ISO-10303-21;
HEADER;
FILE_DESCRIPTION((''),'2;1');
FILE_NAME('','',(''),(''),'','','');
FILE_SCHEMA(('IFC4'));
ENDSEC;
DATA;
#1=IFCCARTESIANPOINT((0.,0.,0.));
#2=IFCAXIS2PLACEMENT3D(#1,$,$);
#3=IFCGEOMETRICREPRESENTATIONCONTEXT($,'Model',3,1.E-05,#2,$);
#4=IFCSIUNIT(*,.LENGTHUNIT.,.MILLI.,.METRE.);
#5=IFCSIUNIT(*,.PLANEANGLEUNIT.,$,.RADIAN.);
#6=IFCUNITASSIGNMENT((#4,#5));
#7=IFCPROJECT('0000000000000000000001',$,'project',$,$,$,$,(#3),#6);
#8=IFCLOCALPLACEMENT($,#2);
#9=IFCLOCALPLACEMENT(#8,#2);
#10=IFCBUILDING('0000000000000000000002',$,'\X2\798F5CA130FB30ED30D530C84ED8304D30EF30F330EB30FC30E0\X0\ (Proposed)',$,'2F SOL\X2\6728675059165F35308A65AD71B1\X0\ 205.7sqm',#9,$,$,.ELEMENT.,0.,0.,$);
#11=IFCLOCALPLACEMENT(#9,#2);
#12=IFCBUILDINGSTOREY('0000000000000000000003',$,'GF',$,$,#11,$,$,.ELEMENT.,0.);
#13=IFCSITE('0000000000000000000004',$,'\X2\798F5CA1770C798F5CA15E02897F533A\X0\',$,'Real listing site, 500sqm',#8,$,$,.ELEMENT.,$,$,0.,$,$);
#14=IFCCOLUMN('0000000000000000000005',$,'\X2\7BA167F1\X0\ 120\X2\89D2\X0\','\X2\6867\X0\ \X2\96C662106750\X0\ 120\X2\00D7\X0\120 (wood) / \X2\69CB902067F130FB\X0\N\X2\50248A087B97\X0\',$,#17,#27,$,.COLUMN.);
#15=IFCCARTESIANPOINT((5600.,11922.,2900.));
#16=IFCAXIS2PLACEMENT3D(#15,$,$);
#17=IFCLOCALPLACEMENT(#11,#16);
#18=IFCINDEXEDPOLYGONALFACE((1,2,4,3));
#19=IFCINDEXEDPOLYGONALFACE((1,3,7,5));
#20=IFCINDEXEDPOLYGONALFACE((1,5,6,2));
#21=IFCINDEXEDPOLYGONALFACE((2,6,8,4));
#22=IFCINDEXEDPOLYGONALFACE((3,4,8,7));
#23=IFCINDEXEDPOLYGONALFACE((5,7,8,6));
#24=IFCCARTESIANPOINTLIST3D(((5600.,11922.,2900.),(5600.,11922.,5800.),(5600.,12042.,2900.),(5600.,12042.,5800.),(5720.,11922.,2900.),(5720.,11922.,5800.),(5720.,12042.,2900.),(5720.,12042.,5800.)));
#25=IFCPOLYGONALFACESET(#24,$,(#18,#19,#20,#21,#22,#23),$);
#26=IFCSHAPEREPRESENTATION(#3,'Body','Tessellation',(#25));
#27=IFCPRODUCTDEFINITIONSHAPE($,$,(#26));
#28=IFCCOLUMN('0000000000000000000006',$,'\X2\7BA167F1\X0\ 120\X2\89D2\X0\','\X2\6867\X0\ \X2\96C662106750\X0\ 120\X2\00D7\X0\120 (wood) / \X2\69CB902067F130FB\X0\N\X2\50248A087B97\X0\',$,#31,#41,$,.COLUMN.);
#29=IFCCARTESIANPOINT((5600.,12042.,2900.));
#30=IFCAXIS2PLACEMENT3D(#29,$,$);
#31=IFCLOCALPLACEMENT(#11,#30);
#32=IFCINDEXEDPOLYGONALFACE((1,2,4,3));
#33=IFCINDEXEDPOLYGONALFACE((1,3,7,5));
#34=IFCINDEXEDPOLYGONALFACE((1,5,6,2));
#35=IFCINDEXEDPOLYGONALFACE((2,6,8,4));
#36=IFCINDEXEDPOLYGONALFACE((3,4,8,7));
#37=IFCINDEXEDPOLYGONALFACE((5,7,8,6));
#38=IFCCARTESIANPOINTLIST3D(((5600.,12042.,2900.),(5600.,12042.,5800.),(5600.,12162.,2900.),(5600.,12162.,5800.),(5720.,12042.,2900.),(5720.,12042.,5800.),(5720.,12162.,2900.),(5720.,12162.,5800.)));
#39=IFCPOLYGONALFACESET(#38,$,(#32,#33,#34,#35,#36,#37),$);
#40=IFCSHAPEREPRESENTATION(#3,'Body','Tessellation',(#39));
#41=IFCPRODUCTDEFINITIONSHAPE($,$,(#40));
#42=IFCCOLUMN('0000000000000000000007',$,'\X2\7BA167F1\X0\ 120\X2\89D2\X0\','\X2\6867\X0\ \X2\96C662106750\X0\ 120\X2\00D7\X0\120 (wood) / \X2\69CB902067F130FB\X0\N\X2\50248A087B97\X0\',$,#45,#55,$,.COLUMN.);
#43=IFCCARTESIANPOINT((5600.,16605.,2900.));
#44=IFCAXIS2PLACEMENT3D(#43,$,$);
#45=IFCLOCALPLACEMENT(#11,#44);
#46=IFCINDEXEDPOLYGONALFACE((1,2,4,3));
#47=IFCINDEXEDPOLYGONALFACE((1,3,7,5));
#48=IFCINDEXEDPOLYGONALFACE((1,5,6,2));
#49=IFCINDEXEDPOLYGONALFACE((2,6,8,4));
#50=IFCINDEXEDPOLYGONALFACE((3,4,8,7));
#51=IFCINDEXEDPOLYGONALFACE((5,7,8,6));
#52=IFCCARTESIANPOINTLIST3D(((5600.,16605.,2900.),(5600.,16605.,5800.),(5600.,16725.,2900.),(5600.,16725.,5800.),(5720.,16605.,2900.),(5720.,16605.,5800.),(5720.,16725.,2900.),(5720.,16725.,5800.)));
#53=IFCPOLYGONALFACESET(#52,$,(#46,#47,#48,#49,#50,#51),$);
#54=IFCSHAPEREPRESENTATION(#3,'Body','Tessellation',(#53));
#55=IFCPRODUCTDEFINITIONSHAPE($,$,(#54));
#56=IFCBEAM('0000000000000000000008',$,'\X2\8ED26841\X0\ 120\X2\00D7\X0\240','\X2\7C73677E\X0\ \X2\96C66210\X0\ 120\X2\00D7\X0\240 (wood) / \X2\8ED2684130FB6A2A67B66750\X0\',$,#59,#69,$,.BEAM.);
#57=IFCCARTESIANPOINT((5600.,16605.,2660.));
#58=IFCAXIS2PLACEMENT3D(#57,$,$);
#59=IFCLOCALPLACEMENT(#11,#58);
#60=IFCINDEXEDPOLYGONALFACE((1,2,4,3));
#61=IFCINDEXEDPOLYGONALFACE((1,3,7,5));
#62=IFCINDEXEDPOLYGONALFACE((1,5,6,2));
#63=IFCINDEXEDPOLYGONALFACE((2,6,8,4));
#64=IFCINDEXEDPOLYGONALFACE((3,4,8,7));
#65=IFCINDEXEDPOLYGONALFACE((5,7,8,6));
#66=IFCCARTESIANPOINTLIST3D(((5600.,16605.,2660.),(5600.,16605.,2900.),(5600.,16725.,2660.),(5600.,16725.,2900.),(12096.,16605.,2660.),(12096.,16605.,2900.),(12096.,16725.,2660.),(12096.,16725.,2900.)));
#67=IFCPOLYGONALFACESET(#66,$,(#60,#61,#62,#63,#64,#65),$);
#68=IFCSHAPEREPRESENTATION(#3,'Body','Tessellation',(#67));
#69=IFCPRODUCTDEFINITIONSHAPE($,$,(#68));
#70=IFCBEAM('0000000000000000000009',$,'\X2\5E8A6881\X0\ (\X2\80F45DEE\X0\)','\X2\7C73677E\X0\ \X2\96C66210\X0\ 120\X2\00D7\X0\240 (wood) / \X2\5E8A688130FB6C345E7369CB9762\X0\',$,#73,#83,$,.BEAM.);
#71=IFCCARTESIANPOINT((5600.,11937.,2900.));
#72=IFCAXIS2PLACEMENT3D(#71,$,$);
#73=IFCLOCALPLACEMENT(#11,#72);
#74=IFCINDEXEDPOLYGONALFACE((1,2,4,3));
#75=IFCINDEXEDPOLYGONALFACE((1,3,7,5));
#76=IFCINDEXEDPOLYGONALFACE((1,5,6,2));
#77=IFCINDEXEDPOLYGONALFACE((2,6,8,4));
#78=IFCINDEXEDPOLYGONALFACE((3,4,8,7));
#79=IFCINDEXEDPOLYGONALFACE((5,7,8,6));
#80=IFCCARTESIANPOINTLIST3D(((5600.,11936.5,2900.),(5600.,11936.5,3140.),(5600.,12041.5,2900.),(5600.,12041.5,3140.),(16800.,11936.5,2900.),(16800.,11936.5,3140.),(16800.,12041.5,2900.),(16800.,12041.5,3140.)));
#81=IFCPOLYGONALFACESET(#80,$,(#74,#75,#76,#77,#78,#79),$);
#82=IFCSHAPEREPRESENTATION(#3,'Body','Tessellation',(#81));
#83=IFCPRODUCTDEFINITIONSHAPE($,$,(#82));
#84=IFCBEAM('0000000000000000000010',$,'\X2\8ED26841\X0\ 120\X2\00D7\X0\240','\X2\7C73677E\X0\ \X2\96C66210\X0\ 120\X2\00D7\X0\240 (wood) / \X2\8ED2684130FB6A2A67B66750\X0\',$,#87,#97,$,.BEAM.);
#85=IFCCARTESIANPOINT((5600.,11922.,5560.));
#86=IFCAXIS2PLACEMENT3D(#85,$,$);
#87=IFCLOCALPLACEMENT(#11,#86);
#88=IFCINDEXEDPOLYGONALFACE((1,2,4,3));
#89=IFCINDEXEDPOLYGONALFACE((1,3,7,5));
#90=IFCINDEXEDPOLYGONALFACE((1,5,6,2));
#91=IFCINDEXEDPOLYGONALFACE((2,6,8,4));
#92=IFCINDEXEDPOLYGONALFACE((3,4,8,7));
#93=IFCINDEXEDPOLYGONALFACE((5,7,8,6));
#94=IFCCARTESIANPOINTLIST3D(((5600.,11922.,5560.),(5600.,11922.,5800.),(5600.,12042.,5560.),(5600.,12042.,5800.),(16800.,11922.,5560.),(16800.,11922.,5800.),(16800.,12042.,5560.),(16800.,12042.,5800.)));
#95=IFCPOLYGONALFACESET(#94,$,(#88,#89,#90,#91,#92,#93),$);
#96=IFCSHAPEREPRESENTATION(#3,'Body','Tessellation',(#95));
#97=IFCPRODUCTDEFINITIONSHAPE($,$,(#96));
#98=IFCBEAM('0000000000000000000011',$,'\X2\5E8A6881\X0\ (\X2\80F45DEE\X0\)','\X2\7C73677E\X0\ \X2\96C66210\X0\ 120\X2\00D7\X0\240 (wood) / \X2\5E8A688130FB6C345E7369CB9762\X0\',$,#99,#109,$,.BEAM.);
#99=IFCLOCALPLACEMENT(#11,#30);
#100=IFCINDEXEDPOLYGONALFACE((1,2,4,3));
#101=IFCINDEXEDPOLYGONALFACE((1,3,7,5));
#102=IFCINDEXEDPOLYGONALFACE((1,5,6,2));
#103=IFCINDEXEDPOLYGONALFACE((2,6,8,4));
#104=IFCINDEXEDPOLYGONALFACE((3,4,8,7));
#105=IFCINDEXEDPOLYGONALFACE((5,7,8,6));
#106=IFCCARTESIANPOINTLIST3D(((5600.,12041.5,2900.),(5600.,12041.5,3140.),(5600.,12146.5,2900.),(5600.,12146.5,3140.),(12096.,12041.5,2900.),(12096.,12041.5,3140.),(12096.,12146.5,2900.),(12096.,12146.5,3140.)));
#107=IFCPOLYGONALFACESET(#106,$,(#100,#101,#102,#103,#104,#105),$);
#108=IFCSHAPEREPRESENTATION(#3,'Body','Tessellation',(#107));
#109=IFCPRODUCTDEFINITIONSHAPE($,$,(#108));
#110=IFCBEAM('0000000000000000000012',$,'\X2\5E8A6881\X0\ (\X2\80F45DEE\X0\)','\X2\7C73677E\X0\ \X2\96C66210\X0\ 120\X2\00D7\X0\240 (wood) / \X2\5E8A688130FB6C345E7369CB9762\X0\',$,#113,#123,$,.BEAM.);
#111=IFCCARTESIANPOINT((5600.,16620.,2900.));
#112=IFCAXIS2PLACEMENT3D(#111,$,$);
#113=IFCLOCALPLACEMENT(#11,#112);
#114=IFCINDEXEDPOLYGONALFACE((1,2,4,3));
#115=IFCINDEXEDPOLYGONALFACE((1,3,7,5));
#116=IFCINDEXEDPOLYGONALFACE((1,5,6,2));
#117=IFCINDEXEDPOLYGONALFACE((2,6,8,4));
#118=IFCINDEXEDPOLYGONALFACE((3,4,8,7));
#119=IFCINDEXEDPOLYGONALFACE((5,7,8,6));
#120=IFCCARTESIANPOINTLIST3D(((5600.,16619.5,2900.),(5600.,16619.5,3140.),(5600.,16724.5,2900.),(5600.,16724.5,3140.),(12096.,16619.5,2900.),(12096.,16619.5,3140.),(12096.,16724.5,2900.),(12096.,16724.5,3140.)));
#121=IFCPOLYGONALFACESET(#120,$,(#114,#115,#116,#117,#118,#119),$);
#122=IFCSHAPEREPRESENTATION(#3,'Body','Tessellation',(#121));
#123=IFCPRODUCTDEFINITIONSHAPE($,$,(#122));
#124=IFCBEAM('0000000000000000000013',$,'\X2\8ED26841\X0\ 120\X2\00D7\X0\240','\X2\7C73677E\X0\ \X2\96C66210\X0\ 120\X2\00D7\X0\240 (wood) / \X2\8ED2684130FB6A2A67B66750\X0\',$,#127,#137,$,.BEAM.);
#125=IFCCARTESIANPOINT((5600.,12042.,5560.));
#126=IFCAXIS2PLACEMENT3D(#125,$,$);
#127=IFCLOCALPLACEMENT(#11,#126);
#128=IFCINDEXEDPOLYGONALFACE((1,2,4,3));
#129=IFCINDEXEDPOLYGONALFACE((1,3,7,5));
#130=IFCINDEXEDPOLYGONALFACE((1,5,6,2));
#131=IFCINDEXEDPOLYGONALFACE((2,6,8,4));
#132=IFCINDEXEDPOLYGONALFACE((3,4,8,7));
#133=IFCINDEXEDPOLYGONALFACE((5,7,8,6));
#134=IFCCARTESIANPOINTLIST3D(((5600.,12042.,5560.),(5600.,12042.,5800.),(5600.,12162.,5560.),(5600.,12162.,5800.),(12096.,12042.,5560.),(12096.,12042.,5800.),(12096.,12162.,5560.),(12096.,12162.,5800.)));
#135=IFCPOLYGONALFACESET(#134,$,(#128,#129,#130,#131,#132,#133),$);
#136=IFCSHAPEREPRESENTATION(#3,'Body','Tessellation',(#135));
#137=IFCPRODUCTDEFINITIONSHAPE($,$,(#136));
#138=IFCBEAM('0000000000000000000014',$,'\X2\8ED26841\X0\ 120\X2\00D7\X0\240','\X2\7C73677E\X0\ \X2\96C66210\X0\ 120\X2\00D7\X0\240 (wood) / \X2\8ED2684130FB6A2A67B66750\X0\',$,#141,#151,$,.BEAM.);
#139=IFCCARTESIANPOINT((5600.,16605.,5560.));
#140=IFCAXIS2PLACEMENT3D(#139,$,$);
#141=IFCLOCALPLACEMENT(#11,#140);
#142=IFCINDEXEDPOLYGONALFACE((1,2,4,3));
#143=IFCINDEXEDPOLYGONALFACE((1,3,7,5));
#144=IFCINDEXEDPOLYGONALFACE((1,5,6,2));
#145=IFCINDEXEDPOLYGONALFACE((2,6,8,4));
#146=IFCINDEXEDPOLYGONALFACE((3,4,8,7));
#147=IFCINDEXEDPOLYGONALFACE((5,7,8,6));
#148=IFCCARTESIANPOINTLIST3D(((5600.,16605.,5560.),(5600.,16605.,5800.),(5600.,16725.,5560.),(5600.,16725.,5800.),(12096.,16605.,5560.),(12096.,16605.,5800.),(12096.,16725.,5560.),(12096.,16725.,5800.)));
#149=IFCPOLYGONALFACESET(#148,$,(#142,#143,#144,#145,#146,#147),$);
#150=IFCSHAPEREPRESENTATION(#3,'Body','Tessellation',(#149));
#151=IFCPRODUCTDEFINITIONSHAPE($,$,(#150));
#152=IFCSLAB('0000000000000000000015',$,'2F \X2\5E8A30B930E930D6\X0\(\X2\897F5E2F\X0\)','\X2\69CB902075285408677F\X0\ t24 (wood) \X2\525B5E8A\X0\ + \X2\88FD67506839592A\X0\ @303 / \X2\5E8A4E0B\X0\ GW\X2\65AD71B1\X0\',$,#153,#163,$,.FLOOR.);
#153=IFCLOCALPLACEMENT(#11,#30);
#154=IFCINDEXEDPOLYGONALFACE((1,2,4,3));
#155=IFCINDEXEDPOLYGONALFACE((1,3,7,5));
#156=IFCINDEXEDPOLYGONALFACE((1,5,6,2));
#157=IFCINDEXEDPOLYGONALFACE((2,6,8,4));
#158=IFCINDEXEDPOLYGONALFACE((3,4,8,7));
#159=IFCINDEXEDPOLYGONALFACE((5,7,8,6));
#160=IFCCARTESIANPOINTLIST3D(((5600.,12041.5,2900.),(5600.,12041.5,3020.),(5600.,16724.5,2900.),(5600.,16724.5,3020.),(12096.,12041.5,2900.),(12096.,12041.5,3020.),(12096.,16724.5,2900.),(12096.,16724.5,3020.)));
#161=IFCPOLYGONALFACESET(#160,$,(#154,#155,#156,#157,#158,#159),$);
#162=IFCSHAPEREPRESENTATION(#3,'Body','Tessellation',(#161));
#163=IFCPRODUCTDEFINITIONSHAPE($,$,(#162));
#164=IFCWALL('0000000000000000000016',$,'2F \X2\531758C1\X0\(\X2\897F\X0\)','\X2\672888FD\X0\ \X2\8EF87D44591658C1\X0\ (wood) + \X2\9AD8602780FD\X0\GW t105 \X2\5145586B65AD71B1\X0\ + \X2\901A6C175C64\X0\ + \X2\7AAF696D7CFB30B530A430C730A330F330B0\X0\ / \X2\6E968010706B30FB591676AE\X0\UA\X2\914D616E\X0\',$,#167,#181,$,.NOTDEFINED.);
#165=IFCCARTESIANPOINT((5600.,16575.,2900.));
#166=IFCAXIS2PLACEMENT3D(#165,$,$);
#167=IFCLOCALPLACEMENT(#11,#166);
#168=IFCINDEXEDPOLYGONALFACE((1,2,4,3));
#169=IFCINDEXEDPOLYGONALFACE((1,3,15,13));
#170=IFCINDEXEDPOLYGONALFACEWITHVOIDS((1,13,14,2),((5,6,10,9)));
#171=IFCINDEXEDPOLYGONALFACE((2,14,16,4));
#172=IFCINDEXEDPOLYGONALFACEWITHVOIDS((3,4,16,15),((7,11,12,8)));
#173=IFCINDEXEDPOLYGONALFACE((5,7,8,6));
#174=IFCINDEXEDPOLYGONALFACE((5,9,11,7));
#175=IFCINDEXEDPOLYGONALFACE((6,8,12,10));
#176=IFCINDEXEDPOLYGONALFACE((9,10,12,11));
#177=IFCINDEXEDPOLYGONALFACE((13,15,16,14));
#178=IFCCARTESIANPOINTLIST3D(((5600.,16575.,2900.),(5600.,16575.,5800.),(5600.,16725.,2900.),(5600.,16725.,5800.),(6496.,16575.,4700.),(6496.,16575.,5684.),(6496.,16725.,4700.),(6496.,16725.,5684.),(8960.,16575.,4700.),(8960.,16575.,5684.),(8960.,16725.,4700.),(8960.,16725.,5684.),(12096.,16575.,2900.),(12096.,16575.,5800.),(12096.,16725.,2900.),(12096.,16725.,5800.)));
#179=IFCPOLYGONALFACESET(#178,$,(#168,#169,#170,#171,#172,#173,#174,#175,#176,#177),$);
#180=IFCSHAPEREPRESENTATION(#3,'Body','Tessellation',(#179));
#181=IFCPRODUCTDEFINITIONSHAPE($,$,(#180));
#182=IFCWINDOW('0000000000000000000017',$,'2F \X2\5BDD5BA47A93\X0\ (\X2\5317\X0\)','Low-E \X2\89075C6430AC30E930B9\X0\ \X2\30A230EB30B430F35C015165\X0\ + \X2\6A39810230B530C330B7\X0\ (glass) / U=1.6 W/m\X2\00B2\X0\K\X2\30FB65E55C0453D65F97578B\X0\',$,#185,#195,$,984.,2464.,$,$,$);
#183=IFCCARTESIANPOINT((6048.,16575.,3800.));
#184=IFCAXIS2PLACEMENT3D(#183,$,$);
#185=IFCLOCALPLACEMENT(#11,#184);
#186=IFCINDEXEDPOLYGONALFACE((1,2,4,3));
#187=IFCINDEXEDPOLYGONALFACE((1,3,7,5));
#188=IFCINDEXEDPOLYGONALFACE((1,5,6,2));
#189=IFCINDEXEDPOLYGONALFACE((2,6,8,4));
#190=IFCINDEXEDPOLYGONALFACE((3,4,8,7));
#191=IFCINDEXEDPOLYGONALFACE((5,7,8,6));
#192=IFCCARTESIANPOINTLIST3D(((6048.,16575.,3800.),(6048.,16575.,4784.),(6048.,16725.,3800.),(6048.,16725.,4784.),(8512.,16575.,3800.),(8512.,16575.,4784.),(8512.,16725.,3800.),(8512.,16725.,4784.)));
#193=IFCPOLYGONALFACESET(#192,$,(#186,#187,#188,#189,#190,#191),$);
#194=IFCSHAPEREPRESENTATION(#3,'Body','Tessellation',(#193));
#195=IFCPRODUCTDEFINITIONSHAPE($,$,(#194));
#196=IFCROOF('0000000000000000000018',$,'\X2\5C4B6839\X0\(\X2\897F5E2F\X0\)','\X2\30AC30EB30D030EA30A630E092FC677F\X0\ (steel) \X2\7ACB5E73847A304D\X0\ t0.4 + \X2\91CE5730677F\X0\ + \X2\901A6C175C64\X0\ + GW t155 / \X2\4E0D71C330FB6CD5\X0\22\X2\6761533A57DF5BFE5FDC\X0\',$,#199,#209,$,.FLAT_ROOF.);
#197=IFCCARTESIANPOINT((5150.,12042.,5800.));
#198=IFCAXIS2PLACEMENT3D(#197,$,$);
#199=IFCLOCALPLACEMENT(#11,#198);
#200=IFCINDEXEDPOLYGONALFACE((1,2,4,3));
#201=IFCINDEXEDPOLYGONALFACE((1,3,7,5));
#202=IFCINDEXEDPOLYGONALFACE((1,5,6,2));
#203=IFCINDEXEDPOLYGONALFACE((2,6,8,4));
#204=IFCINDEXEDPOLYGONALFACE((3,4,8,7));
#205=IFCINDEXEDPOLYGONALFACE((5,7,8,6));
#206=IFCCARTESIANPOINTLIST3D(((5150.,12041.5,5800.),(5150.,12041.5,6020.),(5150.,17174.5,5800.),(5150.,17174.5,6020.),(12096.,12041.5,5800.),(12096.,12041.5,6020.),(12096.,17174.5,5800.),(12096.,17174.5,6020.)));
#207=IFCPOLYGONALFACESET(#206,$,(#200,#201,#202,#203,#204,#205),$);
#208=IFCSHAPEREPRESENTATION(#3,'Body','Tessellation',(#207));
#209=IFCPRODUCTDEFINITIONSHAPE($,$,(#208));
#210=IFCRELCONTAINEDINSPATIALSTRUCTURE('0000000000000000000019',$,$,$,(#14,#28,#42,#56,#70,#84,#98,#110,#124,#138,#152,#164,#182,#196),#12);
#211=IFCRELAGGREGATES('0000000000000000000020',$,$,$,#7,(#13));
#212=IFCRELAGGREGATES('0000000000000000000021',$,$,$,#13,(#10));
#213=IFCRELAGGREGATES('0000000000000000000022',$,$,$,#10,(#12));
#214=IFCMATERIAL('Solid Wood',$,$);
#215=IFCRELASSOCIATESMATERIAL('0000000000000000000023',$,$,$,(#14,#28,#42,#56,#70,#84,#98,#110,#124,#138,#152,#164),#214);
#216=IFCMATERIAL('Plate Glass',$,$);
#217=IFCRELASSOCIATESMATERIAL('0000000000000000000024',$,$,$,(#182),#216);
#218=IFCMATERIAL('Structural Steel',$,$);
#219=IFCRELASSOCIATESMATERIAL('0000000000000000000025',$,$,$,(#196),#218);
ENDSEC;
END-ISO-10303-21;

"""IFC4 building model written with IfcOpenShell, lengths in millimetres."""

from ifc_helpers import new_model, si_unit, frame, frame_2d, origin, place, context, project, spatial, rectangle, extrude, material, element, fill, save


model = new_model("IFC4")

# Units and contexts
model_context = context("Model", 3, precision=1e-05, world=origin())
ifc_project = project(units=[si_unit("LENGTHUNIT", "METRE", prefix="MILLI"), si_unit("PLANEANGLEUNIT", "RADIAN")], contexts=[model_context])

# Site, building, storey
site_placement = place(None, origin())
site = spatial("IfcSite", under=ifc_project, at=site_placement, Name="福岡県福岡市西区", ObjectType="Real listing site, 500sqm", CompositionType="ELEMENT", RefElevation=0.0)
building_placement = place(site_placement, origin())
building = spatial("IfcBuilding", under=site, at=building_placement, Name="福岡・ロフト付きワンルーム (Proposed)", ObjectType="2F SOL木材外張り断熱 205.7sqm", CompositionType="ELEMENT", ElevationOfRefHeight=0.0, ElevationOfTerrain=0.0)
storey_placement = place(building_placement, origin())
storey = spatial("IfcBuildingStorey", under=building, at=storey_placement, Name="GF", CompositionType="ELEMENT", Elevation=0.0)

# Columns
ifc_material_1 = material(Name="Solid Wood")
column_1_placement = place(storey_placement, frame((5600.0, 11922.0, 2900.0)))
element("IfcColumn", 1, at=column_1_placement, inside=storey, material=ifc_material_1, Name="管柱 120角", Description="桧 集成材 120×120 (wood) / 構造柱・N値計算", PredefinedType="COLUMN", context=model_context, shape_type="SweptSolid", body=[
    extrude(rectangle(XDim=120.0, YDim=120.0, at=frame_2d((60.0, 60.0))), frame((5600.0, 11922.0, 2900.0)), (0.0, 0.0, 1.0), 2900.0),
])
column_2_placement = place(storey_placement, frame((5600.0, 12042.0, 2900.0)))
element("IfcColumn", 2, at=column_2_placement, inside=storey, material=ifc_material_1, Name="管柱 120角", Description="桧 集成材 120×120 (wood) / 構造柱・N値計算", PredefinedType="COLUMN", context=model_context, shape_type="SweptSolid", body=[
    extrude(rectangle(XDim=120.0, YDim=120.0, at=frame_2d((60.0, 60.0))), frame((5600.0, 12042.0, 2900.0)), (0.0, 0.0, 1.0), 2900.0),
])
column_3_placement = place(storey_placement, frame((5600.0, 16605.0, 2900.0)))
element("IfcColumn", 3, at=column_3_placement, inside=storey, material=ifc_material_1, Name="管柱 120角", Description="桧 集成材 120×120 (wood) / 構造柱・N値計算", PredefinedType="COLUMN", context=model_context, shape_type="SweptSolid", body=[
    extrude(rectangle(XDim=120.0, YDim=120.0, at=frame_2d((60.0, 60.0))), frame((5600.0, 16605.0, 2900.0)), (0.0, 0.0, 1.0), 2900.0),
])

# Beams
beam_1_placement = place(storey_placement, frame((5600.0, 16605.0, 2660.0)))
element("IfcBeam", 4, at=beam_1_placement, inside=storey, material=ifc_material_1, Name="軒桁 120×240", Description="米松 集成 120×240 (wood) / 軒桁・横架材", PredefinedType="BEAM", context=model_context, shape_type="SweptSolid", body=[
    extrude(rectangle(XDim=6496.0, YDim=120.0, at=frame_2d((3248.0, 60.0))), frame((5600.0, 16605.0, 2660.0)), (0.0, 0.0, 1.0), 240.0),
])
beam_2_placement = place(storey_placement, frame((5600.0, 11937.0, 2900.0)))
element("IfcBeam", 5, at=beam_2_placement, inside=storey, material=ifc_material_1, Name="床梁 (胴差)", Description="米松 集成 120×240 (wood) / 床梁・水平構面", PredefinedType="BEAM", context=model_context, shape_type="SweptSolid", body=[
    extrude(rectangle(XDim=11200.0, YDim=105.0, at=frame_2d((5600.0, 52.0))), frame((5600.0, 11937.0, 2900.0)), (0.0, 0.0, 1.0), 240.0),
])
beam_3_placement = place(storey_placement, frame((5600.0, 11922.0, 5560.0)))
element("IfcBeam", 6, at=beam_3_placement, inside=storey, material=ifc_material_1, Name="軒桁 120×240", Description="米松 集成 120×240 (wood) / 軒桁・横架材", PredefinedType="BEAM", context=model_context, shape_type="SweptSolid", body=[
    extrude(rectangle(XDim=11200.0, YDim=120.0, at=frame_2d((5600.0, 60.0))), frame((5600.0, 11922.0, 5560.0)), (0.0, 0.0, 1.0), 240.0),
])
beam_4_placement = place(storey_placement, frame((5600.0, 12042.0, 2900.0)))
element("IfcBeam", 7, at=beam_4_placement, inside=storey, material=ifc_material_1, Name="床梁 (胴差)", Description="米松 集成 120×240 (wood) / 床梁・水平構面", PredefinedType="BEAM", context=model_context, shape_type="SweptSolid", body=[
    extrude(rectangle(XDim=6496.0, YDim=105.0, at=frame_2d((3248.0, 52.0))), frame((5600.0, 12042.0, 2900.0)), (0.0, 0.0, 1.0), 240.0),
])
beam_5_placement = place(storey_placement, frame((5600.0, 16620.0, 2900.0)))
element("IfcBeam", 8, at=beam_5_placement, inside=storey, material=ifc_material_1, Name="床梁 (胴差)", Description="米松 集成 120×240 (wood) / 床梁・水平構面", PredefinedType="BEAM", context=model_context, shape_type="SweptSolid", body=[
    extrude(rectangle(XDim=6496.0, YDim=105.0, at=frame_2d((3248.0, 52.0))), frame((5600.0, 16620.0, 2900.0)), (0.0, 0.0, 1.0), 240.0),
])
beam_6_placement = place(storey_placement, frame((5600.0, 12042.0, 5560.0)))
element("IfcBeam", 9, at=beam_6_placement, inside=storey, material=ifc_material_1, Name="軒桁 120×240", Description="米松 集成 120×240 (wood) / 軒桁・横架材", PredefinedType="BEAM", context=model_context, shape_type="SweptSolid", body=[
    extrude(rectangle(XDim=6496.0, YDim=120.0, at=frame_2d((3248.0, 60.0))), frame((5600.0, 12042.0, 5560.0)), (0.0, 0.0, 1.0), 240.0),
])
beam_7_placement = place(storey_placement, frame((5600.0, 16605.0, 5560.0)))
element("IfcBeam", 10, at=beam_7_placement, inside=storey, material=ifc_material_1, Name="軒桁 120×240", Description="米松 集成 120×240 (wood) / 軒桁・横架材", PredefinedType="BEAM", context=model_context, shape_type="SweptSolid", body=[
    extrude(rectangle(XDim=6496.0, YDim=120.0, at=frame_2d((3248.0, 60.0))), frame((5600.0, 16605.0, 5560.0)), (0.0, 0.0, 1.0), 240.0),
])

# Slab
slab_placement = place(storey_placement, frame((5600.0, 12042.0, 2900.0)))
element("IfcSlab", 11, at=slab_placement, inside=storey, material=ifc_material_1, Name="2F 床スラブ(西帯)", Description="構造用合板 t24 (wood) 剛床 + 製材根太 @303 / 床下 GW断熱", PredefinedType="FLOOR", context=model_context, shape_type="SweptSolid", body=[
    extrude(rectangle(XDim=6496.0, YDim=4683.0, at=frame_2d((3248.0, 2341.0))), frame((5600.0, 12042.0, 2900.0)), (0.0, 0.0, 1.0), 120.0),
])

# Wall, opening, window
wall_1_placement = place(storey_placement, frame((5600.0, 16575.0, 2900.0)))
wall_1 = element("IfcWall", 12, at=wall_1_placement, inside=storey, material=ifc_material_1, Name="2F 北壁(西)", Description="木製 軸組外壁 (wood) + 高性能GW t105 充填断熱 + 通気層 + 窯業系サイディング / 準耐火・外皮UA配慮", PredefinedType="NOTDEFINED", context=model_context, shape_type="SweptSolid", body=[
    extrude(rectangle(XDim=6496.0, YDim=150.0, at=frame_2d((3248.0, 75.0))), frame((5600.0, 16575.0, 2900.0)), (0.0, 0.0, 1.0), 2900.0),
])
opening_placement = place(storey_placement, frame((6048.0, 16575.0, 3800.0)))
opening = element("IfcOpeningElement", 13, at=opening_placement, cuts=wall_1, PredefinedType="NOTDEFINED", context=model_context, shape_type="SweptSolid", body=[
    extrude(rectangle(XDim=2464.0, YDim=150.0, at=frame_2d((1232.0, 75.0))), frame((6048.0, 16575.0, 3800.0)), (0.0, 0.0, 1.0), 984.0),
])
ifc_material_2 = material(Name="Plate Glass")
window_placement = place(storey_placement, frame((6048.0, 16575.0, 3800.0)))
window = element("IfcWindow", 14, at=window_placement, inside=storey, material=ifc_material_2, Name="2F 寝室窓 (北)", Description="Low-E 複層ガラス アルゴン封入 + 樹脂サッシ (glass) / U=1.6 W/m²K・日射取得型", OverallHeight=984.0, OverallWidth=2464.0, context=model_context, shape_type="SweptSolid", body=[
    extrude(rectangle(XDim=2464.0, YDim=150.0, at=frame_2d((1232.0, 75.0))), frame((6048.0, 16575.0, 3800.0)), (0.0, 0.0, 1.0), 984.0),
])
fill(opening, window)

# Roof
ifc_material_3 = material(Name="Structural Steel")
for number, where, name in (
    (15, (5150.0, 12042.0, 5800.0), "屋根(西帯)"),
):
    element("IfcRoof", number, at=place(storey_placement, frame(where)), inside=storey, material=ifc_material_3, Name=name, Description="ガルバリウム鋼板 (steel) 立平葺き t0.4 + 野地板 + 通気層 + GW t155 / 不燃・法22条区域対応", PredefinedType="FLAT_ROOF", context=model_context, shape_type="SweptSolid", body=[
        extrude(rectangle(XDim=6946.0, YDim=5133.0, at=frame_2d((3473.0, 2566.0))), frame((5150.0, 12042.0, 5800.0)), (0.0, 0.0, 1.0), 220.0),
    ])

save(model, "model.ifc")
